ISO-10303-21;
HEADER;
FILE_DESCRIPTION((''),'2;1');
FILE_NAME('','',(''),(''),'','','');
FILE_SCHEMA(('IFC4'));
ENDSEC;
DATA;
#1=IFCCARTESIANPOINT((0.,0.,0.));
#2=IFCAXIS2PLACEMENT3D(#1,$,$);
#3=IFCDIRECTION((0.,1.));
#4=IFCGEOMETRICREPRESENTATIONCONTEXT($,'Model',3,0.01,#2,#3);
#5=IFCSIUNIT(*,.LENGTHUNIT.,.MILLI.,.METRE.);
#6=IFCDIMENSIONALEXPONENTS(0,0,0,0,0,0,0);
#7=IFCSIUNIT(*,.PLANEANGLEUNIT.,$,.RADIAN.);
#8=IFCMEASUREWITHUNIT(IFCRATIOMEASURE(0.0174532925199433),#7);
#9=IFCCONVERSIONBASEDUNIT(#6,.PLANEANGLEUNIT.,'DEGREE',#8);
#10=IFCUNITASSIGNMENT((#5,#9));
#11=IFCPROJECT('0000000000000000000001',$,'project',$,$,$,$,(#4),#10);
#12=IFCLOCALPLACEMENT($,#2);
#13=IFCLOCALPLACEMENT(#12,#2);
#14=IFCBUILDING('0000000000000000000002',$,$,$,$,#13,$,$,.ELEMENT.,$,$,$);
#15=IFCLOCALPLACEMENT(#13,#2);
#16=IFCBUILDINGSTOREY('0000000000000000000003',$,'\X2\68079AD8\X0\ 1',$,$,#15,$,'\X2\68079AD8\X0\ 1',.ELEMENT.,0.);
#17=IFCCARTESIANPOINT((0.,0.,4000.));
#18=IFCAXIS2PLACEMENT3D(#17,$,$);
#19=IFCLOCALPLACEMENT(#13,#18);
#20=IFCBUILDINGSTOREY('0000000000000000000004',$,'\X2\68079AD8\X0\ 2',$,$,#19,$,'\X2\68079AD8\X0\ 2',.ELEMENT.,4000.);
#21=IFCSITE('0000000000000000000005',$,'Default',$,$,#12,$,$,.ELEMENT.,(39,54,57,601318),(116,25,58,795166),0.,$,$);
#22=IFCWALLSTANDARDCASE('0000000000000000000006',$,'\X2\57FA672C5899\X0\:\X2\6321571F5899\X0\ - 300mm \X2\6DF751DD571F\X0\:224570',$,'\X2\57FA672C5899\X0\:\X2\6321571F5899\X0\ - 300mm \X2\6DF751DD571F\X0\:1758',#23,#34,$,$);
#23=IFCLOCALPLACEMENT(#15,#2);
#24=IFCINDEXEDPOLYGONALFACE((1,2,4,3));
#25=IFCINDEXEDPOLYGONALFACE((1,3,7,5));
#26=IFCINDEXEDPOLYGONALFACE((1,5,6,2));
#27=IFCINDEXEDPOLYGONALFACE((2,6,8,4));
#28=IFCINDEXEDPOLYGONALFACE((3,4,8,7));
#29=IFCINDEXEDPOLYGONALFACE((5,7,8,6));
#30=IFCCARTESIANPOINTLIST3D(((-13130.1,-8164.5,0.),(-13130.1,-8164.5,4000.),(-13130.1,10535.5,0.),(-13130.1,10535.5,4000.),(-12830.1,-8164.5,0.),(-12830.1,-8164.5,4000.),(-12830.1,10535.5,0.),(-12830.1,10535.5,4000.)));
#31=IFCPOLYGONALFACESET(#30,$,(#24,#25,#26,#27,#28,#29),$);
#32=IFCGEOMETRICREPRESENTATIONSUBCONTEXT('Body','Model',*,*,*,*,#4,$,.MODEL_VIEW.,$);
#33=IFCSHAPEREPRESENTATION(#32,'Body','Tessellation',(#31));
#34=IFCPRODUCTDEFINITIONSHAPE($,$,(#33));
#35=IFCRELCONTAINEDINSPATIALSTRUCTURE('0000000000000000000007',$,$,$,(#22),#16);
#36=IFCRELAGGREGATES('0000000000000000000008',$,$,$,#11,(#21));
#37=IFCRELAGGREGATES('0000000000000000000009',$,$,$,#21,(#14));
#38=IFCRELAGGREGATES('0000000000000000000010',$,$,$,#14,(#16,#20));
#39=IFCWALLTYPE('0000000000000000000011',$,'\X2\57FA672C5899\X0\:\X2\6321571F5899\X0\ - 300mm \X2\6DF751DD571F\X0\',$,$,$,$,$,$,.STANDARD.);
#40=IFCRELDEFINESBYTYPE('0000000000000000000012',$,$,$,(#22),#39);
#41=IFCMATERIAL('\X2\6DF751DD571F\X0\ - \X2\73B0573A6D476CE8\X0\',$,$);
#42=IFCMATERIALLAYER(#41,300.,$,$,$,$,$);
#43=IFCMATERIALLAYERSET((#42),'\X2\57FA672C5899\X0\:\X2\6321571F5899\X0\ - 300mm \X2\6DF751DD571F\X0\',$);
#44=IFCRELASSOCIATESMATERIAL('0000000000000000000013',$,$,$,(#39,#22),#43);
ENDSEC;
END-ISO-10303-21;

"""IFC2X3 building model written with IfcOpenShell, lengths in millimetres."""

from ifc_helpers import new_model, entity, si_unit, converted_unit, direction, frame, frame_2d, origin, place, context, subcontext, project, spatial, rectangle, extrude, material, layer, layer_set, layer_usage, type_object, element, save


model = new_model("IFC2X3")

# Units and contexts
model_context = context("Model", 3, precision=0.01, world=origin(), true_north=direction((0.0, 1.0)))
body_context = subcontext(model_context, "Body", "Model", "MODEL_VIEW")
ifc_project = project(units=[si_unit("LENGTHUNIT", "METRE", prefix="MILLI"), converted_unit("PLANEANGLEUNIT", "DEGREE", entity("IfcRatioMeasure", 0.0174532925199433), si_unit("PLANEANGLEUNIT", "RADIAN"), dimensions=[0, 0, 0, 0, 0, 0, 0])], contexts=[model_context])

# Site, building, storey
site_placement = place(None, origin())
site = spatial("IfcSite", under=ifc_project, at=site_placement, Name="Default", CompositionType="ELEMENT", RefLatitude=(39, 54, 57, 601318), RefLongitude=(116, 25, 58, 795166), RefElevation=0.0)
building_placement = place(site_placement, origin())
building = spatial("IfcBuilding", under=site, at=building_placement, CompositionType="ELEMENT")
storey_1_placement = place(building_placement, origin())
storey_1 = spatial("IfcBuildingStorey", under=building, at=storey_1_placement, Name="标高 1", LongName="标高 1", CompositionType="ELEMENT", Elevation=0.0)

# Shared definitions
ifc_material_1 = material(Name="混凝土 - 现场浇注")

# Shared definitions
storey_2_placement = place(building_placement, frame((0.0, 0.0, 4000.0)))
storey_2 = spatial("IfcBuildingStorey", under=building, at=storey_2_placement, Name="标高 2", LongName="标高 2", CompositionType="ELEMENT", Elevation=4000.0)

# Wall
ifc_layer_1 = layer(ifc_material_1, 300.0)
ifc_layer_set_1 = layer_set([ifc_layer_1], Name="基本墙:挡土墙 - 300mm 混凝土")
ifc_layer_usage_1 = layer_usage(ifc_layer_set_1, "AXIS2", "NEGATIVE", 150.0)
wall_type_1 = type_object("IfcWallType", Name="基本墙:挡土墙 - 300mm 混凝土", PredefinedType="STANDARD", material=ifc_layer_set_1)
wall_1_placement = place(storey_1_placement, frame((-12980.1, -8164.5, 0.0), z_axis=(0.0, 0.0, 1.0), x_axis=(0.0, 1.0, 0.0)))
element("IfcWallStandardCase", 1, at=wall_1_placement, inside=storey_1, type_object=wall_type_1, material=ifc_layer_usage_1, Name="基本墙:挡土墙 - 300mm 混凝土:224570", ObjectType="基本墙:挡土墙 - 300mm 混凝土:1758", context=body_context, shape_type="SweptSolid", body=[
    extrude(rectangle(XDim=18700.0, YDim=300.0, at=frame_2d((9350.0, 0.0), x_axis=(-1.0, 0.0))), origin(), (0.0, 0.0, 1.0), 4000.0),
])

save(model, "model.ifc")
